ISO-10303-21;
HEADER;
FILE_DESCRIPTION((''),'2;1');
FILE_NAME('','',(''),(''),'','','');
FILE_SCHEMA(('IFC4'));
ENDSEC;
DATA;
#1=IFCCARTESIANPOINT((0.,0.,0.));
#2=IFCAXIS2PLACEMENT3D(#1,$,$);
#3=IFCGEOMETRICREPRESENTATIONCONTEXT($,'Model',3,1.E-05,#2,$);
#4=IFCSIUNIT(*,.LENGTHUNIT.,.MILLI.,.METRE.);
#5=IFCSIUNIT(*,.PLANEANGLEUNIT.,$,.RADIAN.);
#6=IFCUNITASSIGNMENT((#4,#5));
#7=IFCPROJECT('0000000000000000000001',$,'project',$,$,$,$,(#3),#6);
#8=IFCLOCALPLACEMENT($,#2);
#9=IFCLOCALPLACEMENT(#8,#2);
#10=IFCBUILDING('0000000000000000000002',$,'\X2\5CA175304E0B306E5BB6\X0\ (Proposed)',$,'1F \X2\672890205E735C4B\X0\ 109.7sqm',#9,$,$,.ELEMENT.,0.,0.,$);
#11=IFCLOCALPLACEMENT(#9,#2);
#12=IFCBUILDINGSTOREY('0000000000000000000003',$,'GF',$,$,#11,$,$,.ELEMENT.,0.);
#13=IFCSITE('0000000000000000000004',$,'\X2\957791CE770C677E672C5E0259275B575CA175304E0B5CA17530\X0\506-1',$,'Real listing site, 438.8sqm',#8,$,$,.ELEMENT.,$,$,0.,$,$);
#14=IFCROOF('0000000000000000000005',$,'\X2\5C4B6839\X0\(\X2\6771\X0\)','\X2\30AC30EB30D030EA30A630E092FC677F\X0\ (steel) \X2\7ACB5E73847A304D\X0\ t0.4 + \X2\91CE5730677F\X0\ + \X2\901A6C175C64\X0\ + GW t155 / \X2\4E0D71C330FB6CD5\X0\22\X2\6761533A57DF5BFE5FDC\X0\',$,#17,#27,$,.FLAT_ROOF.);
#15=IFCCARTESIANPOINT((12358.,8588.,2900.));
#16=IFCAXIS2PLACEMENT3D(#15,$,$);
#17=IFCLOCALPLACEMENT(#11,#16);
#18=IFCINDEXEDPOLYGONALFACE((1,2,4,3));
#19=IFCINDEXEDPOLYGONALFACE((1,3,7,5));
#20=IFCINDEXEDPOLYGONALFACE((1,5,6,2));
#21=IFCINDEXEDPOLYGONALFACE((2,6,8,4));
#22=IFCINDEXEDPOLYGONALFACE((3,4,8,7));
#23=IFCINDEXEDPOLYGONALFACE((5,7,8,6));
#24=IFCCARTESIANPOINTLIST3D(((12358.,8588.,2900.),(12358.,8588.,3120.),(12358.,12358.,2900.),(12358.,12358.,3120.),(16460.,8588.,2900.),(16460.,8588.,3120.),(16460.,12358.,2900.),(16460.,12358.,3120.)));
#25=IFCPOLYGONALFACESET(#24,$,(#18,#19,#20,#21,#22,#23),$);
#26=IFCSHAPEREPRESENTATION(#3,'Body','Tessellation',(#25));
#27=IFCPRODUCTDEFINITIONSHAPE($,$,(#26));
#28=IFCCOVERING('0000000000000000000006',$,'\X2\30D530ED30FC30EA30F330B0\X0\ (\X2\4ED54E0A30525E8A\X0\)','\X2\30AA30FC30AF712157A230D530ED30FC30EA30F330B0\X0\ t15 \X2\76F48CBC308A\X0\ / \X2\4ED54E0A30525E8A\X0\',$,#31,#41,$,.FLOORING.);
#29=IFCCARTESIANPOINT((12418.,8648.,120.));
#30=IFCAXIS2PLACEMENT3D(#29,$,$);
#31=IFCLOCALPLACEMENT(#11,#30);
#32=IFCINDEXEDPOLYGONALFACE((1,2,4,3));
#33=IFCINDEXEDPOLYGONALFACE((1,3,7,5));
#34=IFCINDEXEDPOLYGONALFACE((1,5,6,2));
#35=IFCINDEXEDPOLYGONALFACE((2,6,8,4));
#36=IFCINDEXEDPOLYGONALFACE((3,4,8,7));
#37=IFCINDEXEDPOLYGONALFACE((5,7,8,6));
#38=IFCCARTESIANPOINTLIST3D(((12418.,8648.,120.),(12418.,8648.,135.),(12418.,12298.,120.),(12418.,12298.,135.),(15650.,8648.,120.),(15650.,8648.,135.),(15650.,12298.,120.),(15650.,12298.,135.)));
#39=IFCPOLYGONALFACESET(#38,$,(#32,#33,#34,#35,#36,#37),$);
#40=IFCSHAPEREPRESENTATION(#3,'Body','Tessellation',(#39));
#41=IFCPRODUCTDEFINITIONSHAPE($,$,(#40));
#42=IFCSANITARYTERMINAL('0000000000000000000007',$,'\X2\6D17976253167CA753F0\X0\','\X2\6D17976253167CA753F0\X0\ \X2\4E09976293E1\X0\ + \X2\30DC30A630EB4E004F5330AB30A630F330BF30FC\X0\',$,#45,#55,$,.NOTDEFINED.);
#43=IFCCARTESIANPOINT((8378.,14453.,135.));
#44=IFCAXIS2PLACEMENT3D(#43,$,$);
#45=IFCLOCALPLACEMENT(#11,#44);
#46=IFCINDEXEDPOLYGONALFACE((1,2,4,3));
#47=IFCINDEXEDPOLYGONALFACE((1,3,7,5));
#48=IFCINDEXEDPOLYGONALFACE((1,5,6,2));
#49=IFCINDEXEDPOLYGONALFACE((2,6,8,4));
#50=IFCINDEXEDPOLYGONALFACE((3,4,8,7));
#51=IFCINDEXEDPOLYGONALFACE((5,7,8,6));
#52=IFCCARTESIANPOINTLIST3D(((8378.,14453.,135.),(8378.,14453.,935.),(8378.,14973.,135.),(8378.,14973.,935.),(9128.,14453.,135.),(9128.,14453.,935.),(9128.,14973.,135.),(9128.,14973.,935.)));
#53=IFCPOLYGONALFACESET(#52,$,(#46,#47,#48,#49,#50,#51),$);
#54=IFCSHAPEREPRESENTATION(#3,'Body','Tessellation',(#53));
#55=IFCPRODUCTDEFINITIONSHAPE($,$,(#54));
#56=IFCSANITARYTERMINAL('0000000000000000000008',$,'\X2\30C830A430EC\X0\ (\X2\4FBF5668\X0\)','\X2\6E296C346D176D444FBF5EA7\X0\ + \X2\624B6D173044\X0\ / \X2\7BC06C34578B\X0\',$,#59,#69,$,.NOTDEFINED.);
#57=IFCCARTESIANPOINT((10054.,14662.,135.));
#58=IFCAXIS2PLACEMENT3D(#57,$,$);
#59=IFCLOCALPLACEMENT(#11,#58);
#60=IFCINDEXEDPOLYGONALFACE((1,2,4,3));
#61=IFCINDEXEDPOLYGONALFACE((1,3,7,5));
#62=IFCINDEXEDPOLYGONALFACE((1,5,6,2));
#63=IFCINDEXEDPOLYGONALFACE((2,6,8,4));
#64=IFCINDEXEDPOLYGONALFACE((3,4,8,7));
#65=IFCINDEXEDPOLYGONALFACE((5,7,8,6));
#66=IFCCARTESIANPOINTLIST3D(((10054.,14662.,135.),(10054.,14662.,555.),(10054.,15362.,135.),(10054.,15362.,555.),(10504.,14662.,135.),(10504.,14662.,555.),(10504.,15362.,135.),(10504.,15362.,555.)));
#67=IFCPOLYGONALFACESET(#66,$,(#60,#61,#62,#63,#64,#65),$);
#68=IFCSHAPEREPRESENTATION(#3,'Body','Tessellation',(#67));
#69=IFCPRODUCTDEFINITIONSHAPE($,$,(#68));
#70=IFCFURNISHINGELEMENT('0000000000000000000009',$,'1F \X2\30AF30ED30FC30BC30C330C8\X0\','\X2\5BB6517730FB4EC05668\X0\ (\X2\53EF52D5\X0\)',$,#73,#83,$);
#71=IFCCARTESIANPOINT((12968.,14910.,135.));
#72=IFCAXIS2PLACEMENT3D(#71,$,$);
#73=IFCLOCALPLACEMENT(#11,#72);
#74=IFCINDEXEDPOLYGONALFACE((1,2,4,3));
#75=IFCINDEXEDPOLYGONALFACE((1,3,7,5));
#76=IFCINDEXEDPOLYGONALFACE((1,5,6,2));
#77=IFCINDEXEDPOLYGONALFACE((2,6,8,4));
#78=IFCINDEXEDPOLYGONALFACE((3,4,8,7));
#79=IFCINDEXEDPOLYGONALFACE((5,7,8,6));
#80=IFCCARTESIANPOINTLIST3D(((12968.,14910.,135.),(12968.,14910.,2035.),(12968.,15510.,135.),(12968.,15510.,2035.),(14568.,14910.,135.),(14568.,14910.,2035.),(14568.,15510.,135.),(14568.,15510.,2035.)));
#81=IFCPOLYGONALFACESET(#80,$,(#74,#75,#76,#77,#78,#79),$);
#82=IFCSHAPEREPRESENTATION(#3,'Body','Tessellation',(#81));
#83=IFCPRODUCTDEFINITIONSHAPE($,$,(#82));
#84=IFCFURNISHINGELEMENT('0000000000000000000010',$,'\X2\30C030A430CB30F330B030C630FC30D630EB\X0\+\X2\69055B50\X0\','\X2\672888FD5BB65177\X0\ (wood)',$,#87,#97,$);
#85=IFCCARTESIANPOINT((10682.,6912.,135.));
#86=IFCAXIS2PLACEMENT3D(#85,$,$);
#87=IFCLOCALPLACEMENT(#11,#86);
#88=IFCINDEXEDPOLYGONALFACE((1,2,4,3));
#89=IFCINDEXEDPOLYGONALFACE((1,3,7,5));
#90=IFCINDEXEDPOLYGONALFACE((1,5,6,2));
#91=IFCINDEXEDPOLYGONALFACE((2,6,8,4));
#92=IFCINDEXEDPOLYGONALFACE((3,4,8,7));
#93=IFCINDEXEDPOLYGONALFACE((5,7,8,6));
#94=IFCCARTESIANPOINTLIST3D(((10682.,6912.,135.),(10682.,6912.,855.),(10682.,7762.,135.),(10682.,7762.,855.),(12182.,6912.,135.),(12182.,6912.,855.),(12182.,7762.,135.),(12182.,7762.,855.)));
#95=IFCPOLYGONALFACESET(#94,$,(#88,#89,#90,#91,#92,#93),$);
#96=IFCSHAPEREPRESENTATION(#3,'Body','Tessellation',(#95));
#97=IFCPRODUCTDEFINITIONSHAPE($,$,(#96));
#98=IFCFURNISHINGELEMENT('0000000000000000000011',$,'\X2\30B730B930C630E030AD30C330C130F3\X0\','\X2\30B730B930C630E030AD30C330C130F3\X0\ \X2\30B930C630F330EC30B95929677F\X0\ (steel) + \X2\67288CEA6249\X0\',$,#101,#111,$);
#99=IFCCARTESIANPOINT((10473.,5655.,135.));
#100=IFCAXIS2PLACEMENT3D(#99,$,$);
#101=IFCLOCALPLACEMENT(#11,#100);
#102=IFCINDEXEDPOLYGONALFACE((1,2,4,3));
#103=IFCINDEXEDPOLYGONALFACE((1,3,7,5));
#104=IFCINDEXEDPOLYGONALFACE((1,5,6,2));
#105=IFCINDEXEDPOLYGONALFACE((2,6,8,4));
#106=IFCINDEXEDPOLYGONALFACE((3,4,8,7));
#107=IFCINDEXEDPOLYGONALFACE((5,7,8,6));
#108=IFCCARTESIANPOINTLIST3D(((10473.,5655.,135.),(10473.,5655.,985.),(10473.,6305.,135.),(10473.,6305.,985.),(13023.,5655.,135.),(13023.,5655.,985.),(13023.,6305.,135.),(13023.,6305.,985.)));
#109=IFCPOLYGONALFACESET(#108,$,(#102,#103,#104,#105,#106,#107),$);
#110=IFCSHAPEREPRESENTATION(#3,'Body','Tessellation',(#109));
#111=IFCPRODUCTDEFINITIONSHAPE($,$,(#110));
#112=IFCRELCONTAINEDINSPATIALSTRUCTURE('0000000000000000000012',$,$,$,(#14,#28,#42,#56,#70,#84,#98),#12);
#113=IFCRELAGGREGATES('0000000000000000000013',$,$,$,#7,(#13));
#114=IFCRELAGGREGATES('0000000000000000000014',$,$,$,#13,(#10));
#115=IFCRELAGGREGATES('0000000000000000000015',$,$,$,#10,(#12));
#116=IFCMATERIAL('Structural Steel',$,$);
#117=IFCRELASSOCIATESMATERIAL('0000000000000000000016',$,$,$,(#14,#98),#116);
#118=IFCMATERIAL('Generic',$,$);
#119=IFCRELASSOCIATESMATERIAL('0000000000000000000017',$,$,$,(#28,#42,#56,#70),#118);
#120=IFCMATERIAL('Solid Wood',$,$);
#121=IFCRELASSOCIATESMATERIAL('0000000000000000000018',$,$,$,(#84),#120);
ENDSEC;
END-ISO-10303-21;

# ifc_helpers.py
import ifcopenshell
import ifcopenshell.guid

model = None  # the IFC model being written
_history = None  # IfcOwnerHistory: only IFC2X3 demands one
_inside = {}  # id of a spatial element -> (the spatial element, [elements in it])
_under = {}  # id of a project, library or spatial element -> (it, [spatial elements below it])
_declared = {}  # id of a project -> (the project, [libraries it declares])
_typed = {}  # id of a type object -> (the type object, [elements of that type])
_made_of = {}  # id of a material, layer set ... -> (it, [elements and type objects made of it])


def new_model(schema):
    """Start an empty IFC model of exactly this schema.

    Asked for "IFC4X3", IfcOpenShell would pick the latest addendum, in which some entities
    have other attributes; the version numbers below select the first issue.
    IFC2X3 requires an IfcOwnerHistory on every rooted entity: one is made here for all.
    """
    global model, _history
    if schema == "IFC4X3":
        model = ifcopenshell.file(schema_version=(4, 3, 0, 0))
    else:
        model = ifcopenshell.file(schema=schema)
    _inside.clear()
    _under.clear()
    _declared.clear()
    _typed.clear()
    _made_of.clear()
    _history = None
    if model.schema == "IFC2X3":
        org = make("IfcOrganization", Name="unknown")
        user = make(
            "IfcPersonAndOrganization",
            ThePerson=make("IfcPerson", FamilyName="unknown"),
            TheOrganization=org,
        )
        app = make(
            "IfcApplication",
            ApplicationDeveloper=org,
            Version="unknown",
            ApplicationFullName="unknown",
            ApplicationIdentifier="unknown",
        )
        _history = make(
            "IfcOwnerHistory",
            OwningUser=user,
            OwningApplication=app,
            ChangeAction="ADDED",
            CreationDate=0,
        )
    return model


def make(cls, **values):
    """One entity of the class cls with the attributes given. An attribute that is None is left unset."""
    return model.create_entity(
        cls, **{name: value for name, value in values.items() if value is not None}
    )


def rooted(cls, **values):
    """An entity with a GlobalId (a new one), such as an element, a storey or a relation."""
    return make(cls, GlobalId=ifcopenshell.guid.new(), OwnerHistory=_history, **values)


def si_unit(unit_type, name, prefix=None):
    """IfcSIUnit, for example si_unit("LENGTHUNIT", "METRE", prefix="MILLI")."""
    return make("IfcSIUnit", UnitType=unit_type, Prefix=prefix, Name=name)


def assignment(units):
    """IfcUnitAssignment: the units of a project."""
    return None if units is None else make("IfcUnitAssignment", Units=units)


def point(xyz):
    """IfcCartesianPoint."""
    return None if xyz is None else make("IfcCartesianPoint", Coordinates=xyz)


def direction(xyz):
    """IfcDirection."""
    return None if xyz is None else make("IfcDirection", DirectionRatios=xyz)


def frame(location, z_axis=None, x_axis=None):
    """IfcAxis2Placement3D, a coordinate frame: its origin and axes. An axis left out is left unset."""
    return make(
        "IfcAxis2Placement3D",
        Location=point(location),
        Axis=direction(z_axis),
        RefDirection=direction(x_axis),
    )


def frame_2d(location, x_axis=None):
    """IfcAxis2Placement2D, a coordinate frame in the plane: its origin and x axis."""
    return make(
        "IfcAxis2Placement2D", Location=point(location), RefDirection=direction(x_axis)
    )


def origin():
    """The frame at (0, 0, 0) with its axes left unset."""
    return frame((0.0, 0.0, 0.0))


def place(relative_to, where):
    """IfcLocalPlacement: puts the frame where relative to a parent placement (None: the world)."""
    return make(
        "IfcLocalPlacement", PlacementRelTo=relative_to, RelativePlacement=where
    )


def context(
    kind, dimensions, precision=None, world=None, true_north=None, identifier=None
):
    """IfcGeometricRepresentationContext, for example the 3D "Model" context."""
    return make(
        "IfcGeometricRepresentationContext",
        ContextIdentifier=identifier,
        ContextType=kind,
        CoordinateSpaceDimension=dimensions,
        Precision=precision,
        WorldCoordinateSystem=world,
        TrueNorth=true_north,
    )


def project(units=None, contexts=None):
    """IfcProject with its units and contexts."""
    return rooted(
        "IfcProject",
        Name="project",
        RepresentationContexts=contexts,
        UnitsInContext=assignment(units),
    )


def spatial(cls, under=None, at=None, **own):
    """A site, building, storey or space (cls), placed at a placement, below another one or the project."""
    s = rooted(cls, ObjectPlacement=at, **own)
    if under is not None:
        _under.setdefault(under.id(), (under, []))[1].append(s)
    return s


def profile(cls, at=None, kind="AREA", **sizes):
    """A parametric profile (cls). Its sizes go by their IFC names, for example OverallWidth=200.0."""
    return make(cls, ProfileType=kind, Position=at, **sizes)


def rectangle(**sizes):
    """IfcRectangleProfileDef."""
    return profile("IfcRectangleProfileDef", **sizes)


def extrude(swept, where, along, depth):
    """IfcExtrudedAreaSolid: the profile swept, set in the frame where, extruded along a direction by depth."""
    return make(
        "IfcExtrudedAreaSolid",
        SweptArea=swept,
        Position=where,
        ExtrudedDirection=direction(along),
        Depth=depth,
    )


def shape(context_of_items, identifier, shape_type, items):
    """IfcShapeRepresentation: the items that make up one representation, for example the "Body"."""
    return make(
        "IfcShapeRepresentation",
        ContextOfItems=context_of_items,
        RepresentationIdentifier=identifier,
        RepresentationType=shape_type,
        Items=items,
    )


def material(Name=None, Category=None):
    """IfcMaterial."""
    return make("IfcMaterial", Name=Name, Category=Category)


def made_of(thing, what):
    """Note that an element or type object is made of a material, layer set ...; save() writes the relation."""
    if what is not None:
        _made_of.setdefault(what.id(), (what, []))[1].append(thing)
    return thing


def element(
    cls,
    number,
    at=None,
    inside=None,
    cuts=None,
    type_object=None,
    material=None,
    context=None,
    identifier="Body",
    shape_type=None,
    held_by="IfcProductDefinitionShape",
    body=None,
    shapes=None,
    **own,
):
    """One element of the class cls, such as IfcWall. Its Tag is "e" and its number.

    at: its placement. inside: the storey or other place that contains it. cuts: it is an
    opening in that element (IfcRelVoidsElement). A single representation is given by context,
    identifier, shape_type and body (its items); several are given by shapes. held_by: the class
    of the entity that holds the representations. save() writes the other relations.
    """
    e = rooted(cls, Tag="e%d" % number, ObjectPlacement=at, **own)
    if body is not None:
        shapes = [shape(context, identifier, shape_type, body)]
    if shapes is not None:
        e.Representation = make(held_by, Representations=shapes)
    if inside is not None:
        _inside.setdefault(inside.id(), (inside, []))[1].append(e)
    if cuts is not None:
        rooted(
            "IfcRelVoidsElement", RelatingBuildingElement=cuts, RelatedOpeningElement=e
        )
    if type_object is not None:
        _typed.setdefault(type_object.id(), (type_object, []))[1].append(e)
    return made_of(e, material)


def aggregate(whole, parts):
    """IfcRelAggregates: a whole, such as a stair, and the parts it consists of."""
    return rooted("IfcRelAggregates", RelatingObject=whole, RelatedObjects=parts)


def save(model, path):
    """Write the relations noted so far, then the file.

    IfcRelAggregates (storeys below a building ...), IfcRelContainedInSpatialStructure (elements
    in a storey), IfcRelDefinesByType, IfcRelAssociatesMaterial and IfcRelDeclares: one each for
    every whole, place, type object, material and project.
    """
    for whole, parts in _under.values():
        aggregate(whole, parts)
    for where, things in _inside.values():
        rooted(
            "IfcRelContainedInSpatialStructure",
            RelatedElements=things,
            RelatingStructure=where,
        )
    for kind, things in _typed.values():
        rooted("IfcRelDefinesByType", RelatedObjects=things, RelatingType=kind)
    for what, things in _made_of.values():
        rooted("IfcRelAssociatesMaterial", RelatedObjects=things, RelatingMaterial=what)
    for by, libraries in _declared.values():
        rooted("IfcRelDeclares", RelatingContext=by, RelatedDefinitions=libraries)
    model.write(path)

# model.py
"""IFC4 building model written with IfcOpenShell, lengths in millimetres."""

from ifc_helpers import new_model, si_unit, frame, frame_2d, origin, place, context, project, spatial, rectangle, extrude, material, element, save


model = new_model("IFC4")

# Units and contexts
model_context = context("Model", 3, precision=1e-05, world=origin())
ifc_project = project(units=[si_unit("LENGTHUNIT", "METRE", prefix="MILLI"), si_unit("PLANEANGLEUNIT", "RADIAN")], contexts=[model_context])

# Site, building, storey
site_placement = place(None, origin())
site = spatial("IfcSite", under=ifc_project, at=site_placement, Name="長野県松本市大字岡田下岡田506-1", ObjectType="Real listing site, 438.8sqm", CompositionType="ELEMENT", RefElevation=0.0)
building_placement = place(site_placement, origin())
building = spatial("IfcBuilding", under=site, at=building_placement, Name="岡田下の家 (Proposed)", ObjectType="1F 木造平屋 109.7sqm", CompositionType="ELEMENT", ElevationOfRefHeight=0.0, ElevationOfTerrain=0.0)
storey_placement = place(building_placement, origin())
storey = spatial("IfcBuildingStorey", under=building, at=storey_placement, Name="GF", CompositionType="ELEMENT", Elevation=0.0)

# Shared definitions
ifc_material_1 = material(Name="Solid Wood")

# Roof
ifc_material_2 = material(Name="Structural Steel")
roof_placement = place(storey_placement, frame((12358.0, 8588.0, 2900.0)))
element("IfcRoof", 1, at=roof_placement, inside=storey, material=ifc_material_2, Name="屋根(東)", Description="ガルバリウム鋼板 (steel) 立平葺き t0.4 + 野地板 + 通気層 + GW t155 / 不燃・法22条区域対応", PredefinedType="FLAT_ROOF", context=model_context, shape_type="SweptSolid", body=[
    extrude(rectangle(XDim=4102.0, YDim=3770.0, at=frame_2d((2051.0, 1885.0))), frame((12358.0, 8588.0, 2900.0)), (0.0, 0.0, 1.0), 220.0),
])

# Covering
ifc_material_3 = material(Name="Generic")
covering_placement = place(storey_placement, frame((12418.0, 8648.0, 120.0)))
element("IfcCovering", 2, at=covering_placement, inside=storey, material=ifc_material_3, Name="フローリング (仕上げ床)", Description="オーク無垢フローリング t15 直貼り / 仕上げ床", PredefinedType="FLOORING", context=model_context, shape_type="SweptSolid", body=[
    extrude(rectangle(XDim=3232.0, YDim=3650.0, at=frame_2d((1616.0, 1825.0))), frame((12418.0, 8648.0, 120.0)), (0.0, 0.0, 1.0), 15.0),
])

# Sanitary terminals
sanitary_terminal_1_placement = place(storey_placement, frame((8378.0, 14453.0, 135.0)))
element("IfcSanitaryTerminal", 3, at=sanitary_terminal_1_placement, inside=storey, material=ifc_material_3, Name="洗面化粧台", Description="洗面化粧台 三面鏡 + ボウル一体カウンター", PredefinedType="NOTDEFINED", context=model_context, shape_type="SweptSolid", body=[
    extrude(rectangle(XDim=750.0, YDim=520.0, at=frame_2d((375.0, 260.0))), frame((8378.0, 14453.0, 135.0)), (0.0, 0.0, 1.0), 800.0),
])
sanitary_terminal_2_placement = place(storey_placement, frame((10054.0, 14662.0, 135.0)))
element("IfcSanitaryTerminal", 4, at=sanitary_terminal_2_placement, inside=storey, material=ifc_material_3, Name="トイレ (便器)", Description="温水洗浄便座 + 手洗い / 節水型", PredefinedType="NOTDEFINED", context=model_context, shape_type="SweptSolid", body=[
    extrude(rectangle(XDim=450.0, YDim=700.0, at=frame_2d((225.0, 350.0))), frame((10054.0, 14662.0, 135.0)), (0.0, 0.0, 1.0), 420.0),
])

# Furnishing elements
furnishing_1_placement = place(storey_placement, frame((12968.0, 14910.0, 135.0)))
element("IfcFurnishingElement", 5, at=furnishing_1_placement, inside=storey, material=ifc_material_3, Name="1F クローゼット", Description="家具・什器 (可動)", context=model_context, shape_type="SweptSolid", body=[
    extrude(rectangle(XDim=1600.0, YDim=600.0, at=frame_2d((800.0, 300.0))), frame((12968.0, 14910.0, 135.0)), (0.0, 0.0, 1.0), 1900.0),
])
furnishing_2_placement = place(storey_placement, frame((10682.0, 6912.0, 135.0)))
element("IfcFurnishingElement", 6, at=furnishing_2_placement, inside=storey, material=ifc_material_1, Name="ダイニングテーブル+椅子", Description="木製家具 (wood)", context=model_context, shape_type="SweptSolid", body=[
    extrude(rectangle(XDim=1500.0, YDim=850.0, at=frame_2d((750.0, 425.0))), frame((10682.0, 6912.0, 135.0)), (0.0, 0.0, 1.0), 720.0),
])
furnishing_3_placement = place(storey_placement, frame((10473.0, 5655.0, 135.0)))
element("IfcFurnishingElement", 7, at=furnishing_3_placement, inside=storey, material=ifc_material_2, Name="システムキッチン", Description="システムキッチン ステンレス天板 (steel) + 木質扉", context=model_context, shape_type="SweptSolid", body=[
    extrude(rectangle(XDim=2550.0, YDim=650.0, at=frame_2d((1275.0, 325.0))), frame((10473.0, 5655.0, 135.0)), (0.0, 0.0, 1.0), 850.0),
])

save(model, "model.ifc")
